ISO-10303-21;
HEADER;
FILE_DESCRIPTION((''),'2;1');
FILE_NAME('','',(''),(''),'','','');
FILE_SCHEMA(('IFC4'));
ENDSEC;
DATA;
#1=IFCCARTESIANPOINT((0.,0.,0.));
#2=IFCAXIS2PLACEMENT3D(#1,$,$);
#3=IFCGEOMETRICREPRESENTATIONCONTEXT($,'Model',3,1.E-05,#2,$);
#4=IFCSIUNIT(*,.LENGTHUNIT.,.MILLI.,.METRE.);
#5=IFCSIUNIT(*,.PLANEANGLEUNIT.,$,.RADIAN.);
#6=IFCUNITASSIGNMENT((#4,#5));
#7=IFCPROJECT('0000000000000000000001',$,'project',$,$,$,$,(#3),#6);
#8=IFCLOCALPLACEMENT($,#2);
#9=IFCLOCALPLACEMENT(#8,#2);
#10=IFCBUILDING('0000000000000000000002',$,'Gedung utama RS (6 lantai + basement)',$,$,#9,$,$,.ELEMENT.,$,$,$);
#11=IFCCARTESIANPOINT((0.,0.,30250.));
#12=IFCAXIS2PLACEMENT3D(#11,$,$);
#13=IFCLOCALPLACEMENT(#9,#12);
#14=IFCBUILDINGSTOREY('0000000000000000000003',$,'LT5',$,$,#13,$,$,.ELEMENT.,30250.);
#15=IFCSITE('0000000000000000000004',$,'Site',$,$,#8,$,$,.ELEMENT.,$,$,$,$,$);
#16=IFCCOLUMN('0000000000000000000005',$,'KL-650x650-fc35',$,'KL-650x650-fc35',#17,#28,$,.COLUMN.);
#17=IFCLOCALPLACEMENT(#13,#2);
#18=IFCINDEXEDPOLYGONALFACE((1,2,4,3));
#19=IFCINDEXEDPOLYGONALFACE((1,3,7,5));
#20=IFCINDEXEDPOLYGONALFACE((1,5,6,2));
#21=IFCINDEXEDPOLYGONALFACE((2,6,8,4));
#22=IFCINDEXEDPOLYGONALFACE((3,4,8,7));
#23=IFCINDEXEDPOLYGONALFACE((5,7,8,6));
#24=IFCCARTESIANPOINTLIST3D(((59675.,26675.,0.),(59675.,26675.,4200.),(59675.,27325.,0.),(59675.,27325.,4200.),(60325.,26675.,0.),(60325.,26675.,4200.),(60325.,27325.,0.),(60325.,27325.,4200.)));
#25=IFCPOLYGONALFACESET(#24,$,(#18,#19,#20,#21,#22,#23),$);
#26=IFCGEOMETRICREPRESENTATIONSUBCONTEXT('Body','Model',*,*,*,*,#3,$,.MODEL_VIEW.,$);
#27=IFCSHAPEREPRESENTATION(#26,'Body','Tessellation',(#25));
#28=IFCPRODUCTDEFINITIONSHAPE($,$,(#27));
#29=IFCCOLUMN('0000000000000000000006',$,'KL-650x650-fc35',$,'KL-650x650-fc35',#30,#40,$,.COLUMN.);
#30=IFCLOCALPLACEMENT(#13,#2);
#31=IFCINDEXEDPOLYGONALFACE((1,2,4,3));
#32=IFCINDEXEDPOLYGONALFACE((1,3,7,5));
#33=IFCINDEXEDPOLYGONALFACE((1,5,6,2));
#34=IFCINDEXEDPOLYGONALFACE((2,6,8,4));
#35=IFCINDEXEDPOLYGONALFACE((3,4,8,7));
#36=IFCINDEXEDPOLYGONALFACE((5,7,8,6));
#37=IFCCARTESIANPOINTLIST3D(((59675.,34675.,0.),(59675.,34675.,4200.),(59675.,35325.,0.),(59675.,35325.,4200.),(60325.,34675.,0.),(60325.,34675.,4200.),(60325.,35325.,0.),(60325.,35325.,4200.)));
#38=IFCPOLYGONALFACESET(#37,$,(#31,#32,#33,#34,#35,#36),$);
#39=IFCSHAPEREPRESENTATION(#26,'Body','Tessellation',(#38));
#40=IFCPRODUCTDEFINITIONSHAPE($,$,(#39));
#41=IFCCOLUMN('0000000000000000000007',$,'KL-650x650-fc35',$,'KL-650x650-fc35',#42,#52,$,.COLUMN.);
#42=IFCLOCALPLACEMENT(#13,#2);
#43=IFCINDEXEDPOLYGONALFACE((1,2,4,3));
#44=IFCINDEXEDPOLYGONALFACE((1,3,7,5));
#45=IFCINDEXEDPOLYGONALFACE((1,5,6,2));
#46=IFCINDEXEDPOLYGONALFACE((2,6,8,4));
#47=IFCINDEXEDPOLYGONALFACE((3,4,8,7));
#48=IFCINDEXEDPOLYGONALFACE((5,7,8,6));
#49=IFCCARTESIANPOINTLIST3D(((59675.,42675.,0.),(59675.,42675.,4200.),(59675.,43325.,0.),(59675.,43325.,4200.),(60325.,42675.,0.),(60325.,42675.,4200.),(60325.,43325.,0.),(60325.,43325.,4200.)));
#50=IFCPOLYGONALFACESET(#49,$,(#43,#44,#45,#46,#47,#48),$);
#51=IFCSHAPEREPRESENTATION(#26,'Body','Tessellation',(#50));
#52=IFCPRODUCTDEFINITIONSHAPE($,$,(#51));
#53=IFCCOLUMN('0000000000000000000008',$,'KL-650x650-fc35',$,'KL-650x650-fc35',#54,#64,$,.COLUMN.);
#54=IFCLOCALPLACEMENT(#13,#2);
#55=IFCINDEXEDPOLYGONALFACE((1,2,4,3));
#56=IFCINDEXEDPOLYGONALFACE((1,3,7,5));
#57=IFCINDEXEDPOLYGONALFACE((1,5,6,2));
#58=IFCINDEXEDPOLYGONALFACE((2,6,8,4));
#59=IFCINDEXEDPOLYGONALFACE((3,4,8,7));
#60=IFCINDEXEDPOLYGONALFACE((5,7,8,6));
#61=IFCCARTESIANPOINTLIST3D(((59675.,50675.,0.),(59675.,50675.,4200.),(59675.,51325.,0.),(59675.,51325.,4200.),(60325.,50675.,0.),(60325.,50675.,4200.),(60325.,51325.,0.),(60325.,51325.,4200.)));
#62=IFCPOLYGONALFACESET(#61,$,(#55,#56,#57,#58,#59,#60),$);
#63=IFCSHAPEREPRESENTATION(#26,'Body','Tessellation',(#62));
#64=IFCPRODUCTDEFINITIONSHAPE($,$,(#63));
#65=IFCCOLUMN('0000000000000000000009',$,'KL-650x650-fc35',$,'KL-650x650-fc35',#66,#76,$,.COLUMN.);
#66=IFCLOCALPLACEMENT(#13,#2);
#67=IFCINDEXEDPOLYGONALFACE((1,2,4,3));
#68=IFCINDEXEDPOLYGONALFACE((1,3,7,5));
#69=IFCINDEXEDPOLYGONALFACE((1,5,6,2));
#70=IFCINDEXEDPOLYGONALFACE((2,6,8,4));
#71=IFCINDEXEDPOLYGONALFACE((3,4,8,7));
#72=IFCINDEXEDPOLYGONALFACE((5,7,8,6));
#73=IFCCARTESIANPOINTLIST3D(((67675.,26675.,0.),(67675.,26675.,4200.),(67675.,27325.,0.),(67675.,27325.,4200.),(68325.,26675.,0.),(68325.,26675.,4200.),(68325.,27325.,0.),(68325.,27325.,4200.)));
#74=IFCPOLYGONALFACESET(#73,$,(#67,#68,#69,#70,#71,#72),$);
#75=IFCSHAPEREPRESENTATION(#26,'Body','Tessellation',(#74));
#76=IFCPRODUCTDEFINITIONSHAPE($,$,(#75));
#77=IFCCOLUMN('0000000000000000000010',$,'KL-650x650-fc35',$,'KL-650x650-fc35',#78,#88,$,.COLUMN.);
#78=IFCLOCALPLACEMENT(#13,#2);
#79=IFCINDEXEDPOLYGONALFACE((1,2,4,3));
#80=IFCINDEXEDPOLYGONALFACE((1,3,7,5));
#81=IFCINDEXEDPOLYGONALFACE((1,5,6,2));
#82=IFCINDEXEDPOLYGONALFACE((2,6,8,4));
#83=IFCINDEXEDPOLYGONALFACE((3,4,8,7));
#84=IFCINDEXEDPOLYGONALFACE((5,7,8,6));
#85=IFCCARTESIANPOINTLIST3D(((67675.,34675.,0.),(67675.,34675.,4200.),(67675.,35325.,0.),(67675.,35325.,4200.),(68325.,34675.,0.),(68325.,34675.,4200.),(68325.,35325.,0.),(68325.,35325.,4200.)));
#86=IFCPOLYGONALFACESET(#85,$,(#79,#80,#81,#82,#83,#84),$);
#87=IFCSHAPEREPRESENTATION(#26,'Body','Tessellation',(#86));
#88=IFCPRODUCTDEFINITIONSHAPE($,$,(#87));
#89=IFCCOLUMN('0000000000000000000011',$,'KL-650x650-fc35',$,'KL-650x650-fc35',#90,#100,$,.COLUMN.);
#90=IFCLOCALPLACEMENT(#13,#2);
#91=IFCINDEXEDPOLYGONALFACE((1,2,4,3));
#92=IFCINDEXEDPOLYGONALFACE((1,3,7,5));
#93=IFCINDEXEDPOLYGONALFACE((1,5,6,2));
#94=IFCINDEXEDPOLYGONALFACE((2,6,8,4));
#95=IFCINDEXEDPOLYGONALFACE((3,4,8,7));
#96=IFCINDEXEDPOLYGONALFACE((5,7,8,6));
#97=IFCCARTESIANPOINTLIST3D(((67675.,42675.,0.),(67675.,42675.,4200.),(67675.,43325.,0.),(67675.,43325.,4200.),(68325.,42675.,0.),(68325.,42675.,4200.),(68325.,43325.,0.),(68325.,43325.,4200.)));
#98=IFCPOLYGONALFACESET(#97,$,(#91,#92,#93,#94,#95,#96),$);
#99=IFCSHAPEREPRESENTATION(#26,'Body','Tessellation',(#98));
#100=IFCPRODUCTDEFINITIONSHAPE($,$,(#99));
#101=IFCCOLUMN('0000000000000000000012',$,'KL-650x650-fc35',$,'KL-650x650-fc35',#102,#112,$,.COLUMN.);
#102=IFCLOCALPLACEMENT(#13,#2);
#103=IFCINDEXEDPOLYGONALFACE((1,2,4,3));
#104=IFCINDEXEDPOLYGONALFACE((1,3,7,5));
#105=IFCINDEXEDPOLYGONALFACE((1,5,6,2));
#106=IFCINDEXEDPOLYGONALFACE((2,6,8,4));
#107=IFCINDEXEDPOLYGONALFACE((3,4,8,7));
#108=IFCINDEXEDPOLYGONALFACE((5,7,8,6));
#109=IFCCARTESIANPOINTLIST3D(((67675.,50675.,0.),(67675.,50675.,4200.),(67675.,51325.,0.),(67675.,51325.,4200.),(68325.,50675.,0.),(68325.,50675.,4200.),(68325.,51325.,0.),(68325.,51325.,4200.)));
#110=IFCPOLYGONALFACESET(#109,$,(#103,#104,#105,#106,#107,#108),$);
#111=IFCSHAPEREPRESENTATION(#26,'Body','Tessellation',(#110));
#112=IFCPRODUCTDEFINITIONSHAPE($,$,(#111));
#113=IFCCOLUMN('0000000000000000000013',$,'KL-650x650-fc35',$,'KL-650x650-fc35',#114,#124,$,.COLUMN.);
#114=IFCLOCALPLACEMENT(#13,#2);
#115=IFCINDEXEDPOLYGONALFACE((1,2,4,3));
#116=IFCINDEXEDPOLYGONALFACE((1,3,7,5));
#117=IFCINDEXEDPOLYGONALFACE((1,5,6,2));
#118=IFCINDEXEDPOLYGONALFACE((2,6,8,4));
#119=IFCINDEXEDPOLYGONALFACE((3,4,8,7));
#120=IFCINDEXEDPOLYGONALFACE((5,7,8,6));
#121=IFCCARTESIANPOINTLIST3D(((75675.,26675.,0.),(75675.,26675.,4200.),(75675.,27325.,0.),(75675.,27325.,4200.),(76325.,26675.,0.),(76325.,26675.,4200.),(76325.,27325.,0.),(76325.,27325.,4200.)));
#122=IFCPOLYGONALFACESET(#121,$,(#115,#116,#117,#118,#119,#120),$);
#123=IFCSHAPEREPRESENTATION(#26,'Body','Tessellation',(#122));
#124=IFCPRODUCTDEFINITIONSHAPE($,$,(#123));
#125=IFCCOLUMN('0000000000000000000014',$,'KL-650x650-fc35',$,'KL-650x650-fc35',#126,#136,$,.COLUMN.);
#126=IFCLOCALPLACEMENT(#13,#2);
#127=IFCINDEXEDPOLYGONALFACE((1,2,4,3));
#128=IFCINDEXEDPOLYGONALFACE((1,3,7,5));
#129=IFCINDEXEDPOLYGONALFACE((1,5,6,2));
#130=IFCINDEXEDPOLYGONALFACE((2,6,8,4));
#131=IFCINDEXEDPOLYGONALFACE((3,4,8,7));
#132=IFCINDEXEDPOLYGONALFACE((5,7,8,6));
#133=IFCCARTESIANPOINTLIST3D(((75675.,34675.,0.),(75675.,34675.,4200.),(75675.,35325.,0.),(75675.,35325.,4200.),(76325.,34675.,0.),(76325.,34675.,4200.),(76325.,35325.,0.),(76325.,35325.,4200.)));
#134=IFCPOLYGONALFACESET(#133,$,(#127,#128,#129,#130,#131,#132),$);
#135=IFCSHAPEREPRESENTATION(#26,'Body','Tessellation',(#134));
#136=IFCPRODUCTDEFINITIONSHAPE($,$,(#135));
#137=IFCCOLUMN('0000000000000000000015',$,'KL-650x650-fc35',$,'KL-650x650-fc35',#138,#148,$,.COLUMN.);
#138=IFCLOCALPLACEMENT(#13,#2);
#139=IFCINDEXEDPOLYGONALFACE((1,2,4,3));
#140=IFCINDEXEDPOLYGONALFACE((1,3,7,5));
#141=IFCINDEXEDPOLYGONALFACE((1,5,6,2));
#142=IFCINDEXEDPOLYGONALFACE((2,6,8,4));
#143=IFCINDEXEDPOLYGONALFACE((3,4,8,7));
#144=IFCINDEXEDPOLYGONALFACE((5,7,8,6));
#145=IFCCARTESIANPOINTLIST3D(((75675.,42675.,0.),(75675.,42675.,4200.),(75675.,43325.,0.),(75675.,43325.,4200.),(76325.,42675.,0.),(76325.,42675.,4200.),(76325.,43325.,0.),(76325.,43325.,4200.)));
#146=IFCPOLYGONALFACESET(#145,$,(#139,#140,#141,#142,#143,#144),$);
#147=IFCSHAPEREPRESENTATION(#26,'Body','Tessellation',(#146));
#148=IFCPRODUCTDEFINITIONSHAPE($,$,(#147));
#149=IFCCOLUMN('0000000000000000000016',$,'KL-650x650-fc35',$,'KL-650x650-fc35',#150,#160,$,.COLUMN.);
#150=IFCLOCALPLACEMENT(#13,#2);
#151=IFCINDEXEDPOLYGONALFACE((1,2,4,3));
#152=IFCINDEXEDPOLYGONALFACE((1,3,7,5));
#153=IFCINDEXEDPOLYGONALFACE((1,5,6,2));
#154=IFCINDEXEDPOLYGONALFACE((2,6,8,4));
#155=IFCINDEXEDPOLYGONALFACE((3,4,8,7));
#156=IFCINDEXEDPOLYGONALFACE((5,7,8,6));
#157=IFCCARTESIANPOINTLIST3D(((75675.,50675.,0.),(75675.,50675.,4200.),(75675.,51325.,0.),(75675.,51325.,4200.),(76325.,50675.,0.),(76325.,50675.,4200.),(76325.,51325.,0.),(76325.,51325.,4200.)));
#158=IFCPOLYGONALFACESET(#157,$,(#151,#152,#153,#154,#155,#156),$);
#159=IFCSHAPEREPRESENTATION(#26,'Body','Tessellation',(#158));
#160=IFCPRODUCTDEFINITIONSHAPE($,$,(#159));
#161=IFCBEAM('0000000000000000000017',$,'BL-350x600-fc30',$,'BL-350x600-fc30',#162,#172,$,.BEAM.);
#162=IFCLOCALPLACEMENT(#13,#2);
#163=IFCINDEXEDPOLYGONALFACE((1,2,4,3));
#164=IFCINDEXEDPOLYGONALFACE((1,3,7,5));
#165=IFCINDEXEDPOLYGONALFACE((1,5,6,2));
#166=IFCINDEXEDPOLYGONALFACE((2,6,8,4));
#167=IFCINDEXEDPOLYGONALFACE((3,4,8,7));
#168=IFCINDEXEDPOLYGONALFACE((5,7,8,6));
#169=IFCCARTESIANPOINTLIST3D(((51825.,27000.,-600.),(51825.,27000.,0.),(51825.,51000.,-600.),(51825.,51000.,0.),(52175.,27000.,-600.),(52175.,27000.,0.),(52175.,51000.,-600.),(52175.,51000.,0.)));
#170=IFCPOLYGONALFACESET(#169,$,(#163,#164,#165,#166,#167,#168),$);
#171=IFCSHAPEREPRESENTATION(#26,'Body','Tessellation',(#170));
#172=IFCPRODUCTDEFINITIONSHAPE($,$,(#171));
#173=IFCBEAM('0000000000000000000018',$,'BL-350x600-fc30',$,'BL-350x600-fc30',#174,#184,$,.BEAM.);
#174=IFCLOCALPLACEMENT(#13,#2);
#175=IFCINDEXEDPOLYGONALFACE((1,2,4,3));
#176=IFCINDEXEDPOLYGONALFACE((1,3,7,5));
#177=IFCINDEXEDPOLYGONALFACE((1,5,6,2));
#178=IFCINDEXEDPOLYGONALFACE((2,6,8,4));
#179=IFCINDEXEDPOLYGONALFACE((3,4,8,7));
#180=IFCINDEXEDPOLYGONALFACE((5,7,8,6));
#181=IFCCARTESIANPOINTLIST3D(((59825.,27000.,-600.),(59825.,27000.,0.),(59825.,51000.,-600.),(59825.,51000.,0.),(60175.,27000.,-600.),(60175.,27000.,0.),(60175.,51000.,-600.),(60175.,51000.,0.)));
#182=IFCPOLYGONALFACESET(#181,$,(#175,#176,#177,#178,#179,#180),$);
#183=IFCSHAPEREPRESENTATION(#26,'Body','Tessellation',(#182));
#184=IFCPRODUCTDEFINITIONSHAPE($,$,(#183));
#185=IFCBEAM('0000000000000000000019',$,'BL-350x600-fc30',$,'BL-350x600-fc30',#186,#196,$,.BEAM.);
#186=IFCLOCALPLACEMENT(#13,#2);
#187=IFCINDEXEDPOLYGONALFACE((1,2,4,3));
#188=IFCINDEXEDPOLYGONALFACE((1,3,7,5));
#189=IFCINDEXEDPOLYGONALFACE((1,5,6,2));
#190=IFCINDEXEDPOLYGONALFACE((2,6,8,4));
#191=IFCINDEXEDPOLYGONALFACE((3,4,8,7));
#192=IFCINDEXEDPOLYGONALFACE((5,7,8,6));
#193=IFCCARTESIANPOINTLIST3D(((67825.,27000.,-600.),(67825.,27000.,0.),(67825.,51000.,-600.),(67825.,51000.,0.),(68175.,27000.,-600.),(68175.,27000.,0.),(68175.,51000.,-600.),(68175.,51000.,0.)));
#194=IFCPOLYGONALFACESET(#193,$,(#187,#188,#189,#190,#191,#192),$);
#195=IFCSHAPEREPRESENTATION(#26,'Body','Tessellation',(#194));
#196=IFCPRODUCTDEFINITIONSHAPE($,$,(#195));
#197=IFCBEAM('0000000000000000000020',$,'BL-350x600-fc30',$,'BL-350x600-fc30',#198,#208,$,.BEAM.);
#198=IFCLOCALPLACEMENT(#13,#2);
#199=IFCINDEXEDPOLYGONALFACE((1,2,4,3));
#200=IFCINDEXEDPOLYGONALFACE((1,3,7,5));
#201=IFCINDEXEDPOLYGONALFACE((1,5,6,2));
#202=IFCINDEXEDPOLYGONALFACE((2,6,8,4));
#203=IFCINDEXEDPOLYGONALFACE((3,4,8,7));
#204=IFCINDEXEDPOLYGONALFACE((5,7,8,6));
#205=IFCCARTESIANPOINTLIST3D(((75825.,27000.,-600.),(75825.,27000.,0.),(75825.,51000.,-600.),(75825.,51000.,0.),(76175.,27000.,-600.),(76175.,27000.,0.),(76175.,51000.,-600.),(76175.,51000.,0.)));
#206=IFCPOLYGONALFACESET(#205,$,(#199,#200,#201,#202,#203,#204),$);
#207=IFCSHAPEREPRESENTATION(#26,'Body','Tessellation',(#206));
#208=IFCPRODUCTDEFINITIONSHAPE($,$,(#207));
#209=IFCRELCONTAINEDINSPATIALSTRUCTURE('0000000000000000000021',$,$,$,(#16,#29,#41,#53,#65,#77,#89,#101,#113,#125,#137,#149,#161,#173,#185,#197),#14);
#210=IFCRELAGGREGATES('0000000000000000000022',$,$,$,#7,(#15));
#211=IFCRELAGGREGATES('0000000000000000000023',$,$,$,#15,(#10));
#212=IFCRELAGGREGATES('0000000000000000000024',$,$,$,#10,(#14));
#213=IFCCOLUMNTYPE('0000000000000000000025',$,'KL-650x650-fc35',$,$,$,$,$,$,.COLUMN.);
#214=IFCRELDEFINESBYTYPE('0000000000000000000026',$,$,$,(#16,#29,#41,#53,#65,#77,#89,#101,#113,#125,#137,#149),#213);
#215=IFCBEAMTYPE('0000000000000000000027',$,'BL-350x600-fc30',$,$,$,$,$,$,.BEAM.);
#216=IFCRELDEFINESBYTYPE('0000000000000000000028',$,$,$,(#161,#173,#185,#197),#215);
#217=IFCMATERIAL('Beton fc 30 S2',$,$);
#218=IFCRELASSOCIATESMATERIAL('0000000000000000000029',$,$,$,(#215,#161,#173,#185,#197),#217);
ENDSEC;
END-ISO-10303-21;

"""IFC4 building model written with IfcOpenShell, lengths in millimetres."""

from ifc_helpers import new_model, si_unit, frame, origin, origin_2d, place, context, subcontext, project, spatial, rectangle, extrude, material, material_profile, profile_set, profile_usage, type_object, element, save


model = new_model("IFC4")

# Units and contexts
model_context = context("Model", 3, precision=1e-05, world=origin())
body_context = subcontext(model_context, "Body", "Model", "MODEL_VIEW")
ifc_project = project(units=[si_unit("LENGTHUNIT", "METRE", prefix="MILLI"), si_unit("PLANEANGLEUNIT", "RADIAN")], contexts=[model_context])

# Site, building, storey
site_placement = place(None, origin())
site = spatial("IfcSite", under=ifc_project, at=site_placement, Name="Site", CompositionType="ELEMENT")
building_placement = place(site_placement, origin())
building = spatial("IfcBuilding", under=site, at=building_placement, Name="Gedung utama RS (6 lantai + basement)", CompositionType="ELEMENT")
storey_placement = place(building_placement, frame((0.0, 0.0, 30250.0)))
storey = spatial("IfcBuildingStorey", under=building, at=storey_placement, Name="LT5", CompositionType="ELEMENT", Elevation=30250.0)

# Columns
ifc_material_profile_1 = material_profile(None, rectangle(XDim=650.0, YDim=650.0, at=origin_2d()), Name="KL-650x650-fc35")
ifc_profile_set_1 = profile_set([ifc_material_profile_1], Name="KL-650x650-fc35")
ifc_profile_usage_1 = profile_usage(ifc_profile_set_1, cardinal=5)
column_type = type_object("IfcColumnType", Name="KL-650x650-fc35", PredefinedType="COLUMN", material=ifc_profile_set_1)
for number, where, z_axis, x_axis, name in (
    (1, (60000.0, 27000.0, 0.0), (0.0, 0.0, 1.0), (1.0, 0.0, 0.0), "KL-650x650-fc35"),
    (2, (60000.0, 35000.0, 0.0), (0.0, 0.0, 1.0), (1.0, 0.0, 0.0), "KL-650x650-fc35"),
    (3, (60000.0, 43000.0, 0.0), (0.0, 0.0, 1.0), (1.0, 0.0, 0.0), "KL-650x650-fc35"),
    (4, (60000.0, 51000.0, 0.0), (0.0, 0.0, 1.0), (1.0, 0.0, 0.0), "KL-650x650-fc35"),
    (5, (68000.0, 27000.0, 0.0), (0.0, 0.0, 1.0), (1.0, 0.0, 0.0), "KL-650x650-fc35"),
    (6, (68000.0, 35000.0, 0.0), (0.0, 0.0, 1.0), (1.0, 0.0, 0.0), "KL-650x650-fc35"),
    (7, (68000.0, 43000.0, 0.0), (0.0, 0.0, 1.0), (1.0, 0.0, 0.0), "KL-650x650-fc35"),
    (8, (68000.0, 51000.0, 0.0), (0.0, 0.0, 1.0), (1.0, 0.0, 0.0), "KL-650x650-fc35"),
    (9, (76000.0, 27000.0, 0.0), (0.0, 0.0, 1.0), (1.0, 0.0, 0.0), "KL-650x650-fc35"),
    (10, (76000.0, 35000.0, 0.0), (0.0, 0.0, 1.0), (1.0, 0.0, 0.0), "KL-650x650-fc35"),
    (11, (76000.0, 43000.0, 0.0), (0.0, 0.0, 1.0), (1.0, 0.0, 0.0), "KL-650x650-fc35"),
    (12, (76000.0, 51000.0, 0.0), (0.0, 0.0, 1.0), (1.0, 0.0, 0.0), "KL-650x650-fc35"),
):
    element("IfcColumn", number, at=place(storey_placement, frame(where, z_axis=z_axis, x_axis=x_axis)), inside=storey, type_object=column_type, material=ifc_profile_usage_1, Name=name, ObjectType="KL-650x650-fc35", PredefinedType="COLUMN", context=body_context, shape_type="SweptSolid", body=[
        extrude(rectangle(XDim=650.0, YDim=650.0, at=origin_2d()), origin(), (0.0, 0.0, 1.0), 4200.0),
    ])

# Beams
ifc_material = material(Name="Beton fc 30 S2")
ifc_material_profile_2 = material_profile(ifc_material, rectangle(XDim=350.0, YDim=600.0, at=origin_2d()), Name="BL-350x600-fc30")
ifc_profile_set_2 = profile_set([ifc_material_profile_2], Name="BL-350x600-fc30")
ifc_profile_usage_2 = profile_usage(ifc_profile_set_2, cardinal=8)
beam_type = type_object("IfcBeamType", Name="BL-350x600-fc30", PredefinedType="BEAM", material=ifc_profile_set_2)
for number, where, name in (
    (13, (52000.0, 27000.0, -300.0), "BL-350x600-fc30"),
    (14, (60000.0, 27000.0, -300.0), "BL-350x600-fc30"),
    (15, (68000.0, 27000.0, -300.0), "BL-350x600-fc30"),
    (16, (76000.0, 27000.0, -300.0), "BL-350x600-fc30"),
):
    element("IfcBeam", number, at=place(storey_placement, frame(where)), inside=storey, type_object=beam_type, material=ifc_profile_usage_2, Name=name, ObjectType="BL-350x600-fc30", PredefinedType="BEAM", context=body_context, shape_type="SweptSolid", body=[
        extrude(rectangle(XDim=350.0, YDim=600.0, at=origin_2d()), frame((0.0, 0.0, 0.0), z_axis=(0.0, 1.0, 0.0), x_axis=(-1.0, 0.0, 0.0)), (0.0, 0.0, 1.0), 24000.0),
    ])

save(model, "model.ifc")
